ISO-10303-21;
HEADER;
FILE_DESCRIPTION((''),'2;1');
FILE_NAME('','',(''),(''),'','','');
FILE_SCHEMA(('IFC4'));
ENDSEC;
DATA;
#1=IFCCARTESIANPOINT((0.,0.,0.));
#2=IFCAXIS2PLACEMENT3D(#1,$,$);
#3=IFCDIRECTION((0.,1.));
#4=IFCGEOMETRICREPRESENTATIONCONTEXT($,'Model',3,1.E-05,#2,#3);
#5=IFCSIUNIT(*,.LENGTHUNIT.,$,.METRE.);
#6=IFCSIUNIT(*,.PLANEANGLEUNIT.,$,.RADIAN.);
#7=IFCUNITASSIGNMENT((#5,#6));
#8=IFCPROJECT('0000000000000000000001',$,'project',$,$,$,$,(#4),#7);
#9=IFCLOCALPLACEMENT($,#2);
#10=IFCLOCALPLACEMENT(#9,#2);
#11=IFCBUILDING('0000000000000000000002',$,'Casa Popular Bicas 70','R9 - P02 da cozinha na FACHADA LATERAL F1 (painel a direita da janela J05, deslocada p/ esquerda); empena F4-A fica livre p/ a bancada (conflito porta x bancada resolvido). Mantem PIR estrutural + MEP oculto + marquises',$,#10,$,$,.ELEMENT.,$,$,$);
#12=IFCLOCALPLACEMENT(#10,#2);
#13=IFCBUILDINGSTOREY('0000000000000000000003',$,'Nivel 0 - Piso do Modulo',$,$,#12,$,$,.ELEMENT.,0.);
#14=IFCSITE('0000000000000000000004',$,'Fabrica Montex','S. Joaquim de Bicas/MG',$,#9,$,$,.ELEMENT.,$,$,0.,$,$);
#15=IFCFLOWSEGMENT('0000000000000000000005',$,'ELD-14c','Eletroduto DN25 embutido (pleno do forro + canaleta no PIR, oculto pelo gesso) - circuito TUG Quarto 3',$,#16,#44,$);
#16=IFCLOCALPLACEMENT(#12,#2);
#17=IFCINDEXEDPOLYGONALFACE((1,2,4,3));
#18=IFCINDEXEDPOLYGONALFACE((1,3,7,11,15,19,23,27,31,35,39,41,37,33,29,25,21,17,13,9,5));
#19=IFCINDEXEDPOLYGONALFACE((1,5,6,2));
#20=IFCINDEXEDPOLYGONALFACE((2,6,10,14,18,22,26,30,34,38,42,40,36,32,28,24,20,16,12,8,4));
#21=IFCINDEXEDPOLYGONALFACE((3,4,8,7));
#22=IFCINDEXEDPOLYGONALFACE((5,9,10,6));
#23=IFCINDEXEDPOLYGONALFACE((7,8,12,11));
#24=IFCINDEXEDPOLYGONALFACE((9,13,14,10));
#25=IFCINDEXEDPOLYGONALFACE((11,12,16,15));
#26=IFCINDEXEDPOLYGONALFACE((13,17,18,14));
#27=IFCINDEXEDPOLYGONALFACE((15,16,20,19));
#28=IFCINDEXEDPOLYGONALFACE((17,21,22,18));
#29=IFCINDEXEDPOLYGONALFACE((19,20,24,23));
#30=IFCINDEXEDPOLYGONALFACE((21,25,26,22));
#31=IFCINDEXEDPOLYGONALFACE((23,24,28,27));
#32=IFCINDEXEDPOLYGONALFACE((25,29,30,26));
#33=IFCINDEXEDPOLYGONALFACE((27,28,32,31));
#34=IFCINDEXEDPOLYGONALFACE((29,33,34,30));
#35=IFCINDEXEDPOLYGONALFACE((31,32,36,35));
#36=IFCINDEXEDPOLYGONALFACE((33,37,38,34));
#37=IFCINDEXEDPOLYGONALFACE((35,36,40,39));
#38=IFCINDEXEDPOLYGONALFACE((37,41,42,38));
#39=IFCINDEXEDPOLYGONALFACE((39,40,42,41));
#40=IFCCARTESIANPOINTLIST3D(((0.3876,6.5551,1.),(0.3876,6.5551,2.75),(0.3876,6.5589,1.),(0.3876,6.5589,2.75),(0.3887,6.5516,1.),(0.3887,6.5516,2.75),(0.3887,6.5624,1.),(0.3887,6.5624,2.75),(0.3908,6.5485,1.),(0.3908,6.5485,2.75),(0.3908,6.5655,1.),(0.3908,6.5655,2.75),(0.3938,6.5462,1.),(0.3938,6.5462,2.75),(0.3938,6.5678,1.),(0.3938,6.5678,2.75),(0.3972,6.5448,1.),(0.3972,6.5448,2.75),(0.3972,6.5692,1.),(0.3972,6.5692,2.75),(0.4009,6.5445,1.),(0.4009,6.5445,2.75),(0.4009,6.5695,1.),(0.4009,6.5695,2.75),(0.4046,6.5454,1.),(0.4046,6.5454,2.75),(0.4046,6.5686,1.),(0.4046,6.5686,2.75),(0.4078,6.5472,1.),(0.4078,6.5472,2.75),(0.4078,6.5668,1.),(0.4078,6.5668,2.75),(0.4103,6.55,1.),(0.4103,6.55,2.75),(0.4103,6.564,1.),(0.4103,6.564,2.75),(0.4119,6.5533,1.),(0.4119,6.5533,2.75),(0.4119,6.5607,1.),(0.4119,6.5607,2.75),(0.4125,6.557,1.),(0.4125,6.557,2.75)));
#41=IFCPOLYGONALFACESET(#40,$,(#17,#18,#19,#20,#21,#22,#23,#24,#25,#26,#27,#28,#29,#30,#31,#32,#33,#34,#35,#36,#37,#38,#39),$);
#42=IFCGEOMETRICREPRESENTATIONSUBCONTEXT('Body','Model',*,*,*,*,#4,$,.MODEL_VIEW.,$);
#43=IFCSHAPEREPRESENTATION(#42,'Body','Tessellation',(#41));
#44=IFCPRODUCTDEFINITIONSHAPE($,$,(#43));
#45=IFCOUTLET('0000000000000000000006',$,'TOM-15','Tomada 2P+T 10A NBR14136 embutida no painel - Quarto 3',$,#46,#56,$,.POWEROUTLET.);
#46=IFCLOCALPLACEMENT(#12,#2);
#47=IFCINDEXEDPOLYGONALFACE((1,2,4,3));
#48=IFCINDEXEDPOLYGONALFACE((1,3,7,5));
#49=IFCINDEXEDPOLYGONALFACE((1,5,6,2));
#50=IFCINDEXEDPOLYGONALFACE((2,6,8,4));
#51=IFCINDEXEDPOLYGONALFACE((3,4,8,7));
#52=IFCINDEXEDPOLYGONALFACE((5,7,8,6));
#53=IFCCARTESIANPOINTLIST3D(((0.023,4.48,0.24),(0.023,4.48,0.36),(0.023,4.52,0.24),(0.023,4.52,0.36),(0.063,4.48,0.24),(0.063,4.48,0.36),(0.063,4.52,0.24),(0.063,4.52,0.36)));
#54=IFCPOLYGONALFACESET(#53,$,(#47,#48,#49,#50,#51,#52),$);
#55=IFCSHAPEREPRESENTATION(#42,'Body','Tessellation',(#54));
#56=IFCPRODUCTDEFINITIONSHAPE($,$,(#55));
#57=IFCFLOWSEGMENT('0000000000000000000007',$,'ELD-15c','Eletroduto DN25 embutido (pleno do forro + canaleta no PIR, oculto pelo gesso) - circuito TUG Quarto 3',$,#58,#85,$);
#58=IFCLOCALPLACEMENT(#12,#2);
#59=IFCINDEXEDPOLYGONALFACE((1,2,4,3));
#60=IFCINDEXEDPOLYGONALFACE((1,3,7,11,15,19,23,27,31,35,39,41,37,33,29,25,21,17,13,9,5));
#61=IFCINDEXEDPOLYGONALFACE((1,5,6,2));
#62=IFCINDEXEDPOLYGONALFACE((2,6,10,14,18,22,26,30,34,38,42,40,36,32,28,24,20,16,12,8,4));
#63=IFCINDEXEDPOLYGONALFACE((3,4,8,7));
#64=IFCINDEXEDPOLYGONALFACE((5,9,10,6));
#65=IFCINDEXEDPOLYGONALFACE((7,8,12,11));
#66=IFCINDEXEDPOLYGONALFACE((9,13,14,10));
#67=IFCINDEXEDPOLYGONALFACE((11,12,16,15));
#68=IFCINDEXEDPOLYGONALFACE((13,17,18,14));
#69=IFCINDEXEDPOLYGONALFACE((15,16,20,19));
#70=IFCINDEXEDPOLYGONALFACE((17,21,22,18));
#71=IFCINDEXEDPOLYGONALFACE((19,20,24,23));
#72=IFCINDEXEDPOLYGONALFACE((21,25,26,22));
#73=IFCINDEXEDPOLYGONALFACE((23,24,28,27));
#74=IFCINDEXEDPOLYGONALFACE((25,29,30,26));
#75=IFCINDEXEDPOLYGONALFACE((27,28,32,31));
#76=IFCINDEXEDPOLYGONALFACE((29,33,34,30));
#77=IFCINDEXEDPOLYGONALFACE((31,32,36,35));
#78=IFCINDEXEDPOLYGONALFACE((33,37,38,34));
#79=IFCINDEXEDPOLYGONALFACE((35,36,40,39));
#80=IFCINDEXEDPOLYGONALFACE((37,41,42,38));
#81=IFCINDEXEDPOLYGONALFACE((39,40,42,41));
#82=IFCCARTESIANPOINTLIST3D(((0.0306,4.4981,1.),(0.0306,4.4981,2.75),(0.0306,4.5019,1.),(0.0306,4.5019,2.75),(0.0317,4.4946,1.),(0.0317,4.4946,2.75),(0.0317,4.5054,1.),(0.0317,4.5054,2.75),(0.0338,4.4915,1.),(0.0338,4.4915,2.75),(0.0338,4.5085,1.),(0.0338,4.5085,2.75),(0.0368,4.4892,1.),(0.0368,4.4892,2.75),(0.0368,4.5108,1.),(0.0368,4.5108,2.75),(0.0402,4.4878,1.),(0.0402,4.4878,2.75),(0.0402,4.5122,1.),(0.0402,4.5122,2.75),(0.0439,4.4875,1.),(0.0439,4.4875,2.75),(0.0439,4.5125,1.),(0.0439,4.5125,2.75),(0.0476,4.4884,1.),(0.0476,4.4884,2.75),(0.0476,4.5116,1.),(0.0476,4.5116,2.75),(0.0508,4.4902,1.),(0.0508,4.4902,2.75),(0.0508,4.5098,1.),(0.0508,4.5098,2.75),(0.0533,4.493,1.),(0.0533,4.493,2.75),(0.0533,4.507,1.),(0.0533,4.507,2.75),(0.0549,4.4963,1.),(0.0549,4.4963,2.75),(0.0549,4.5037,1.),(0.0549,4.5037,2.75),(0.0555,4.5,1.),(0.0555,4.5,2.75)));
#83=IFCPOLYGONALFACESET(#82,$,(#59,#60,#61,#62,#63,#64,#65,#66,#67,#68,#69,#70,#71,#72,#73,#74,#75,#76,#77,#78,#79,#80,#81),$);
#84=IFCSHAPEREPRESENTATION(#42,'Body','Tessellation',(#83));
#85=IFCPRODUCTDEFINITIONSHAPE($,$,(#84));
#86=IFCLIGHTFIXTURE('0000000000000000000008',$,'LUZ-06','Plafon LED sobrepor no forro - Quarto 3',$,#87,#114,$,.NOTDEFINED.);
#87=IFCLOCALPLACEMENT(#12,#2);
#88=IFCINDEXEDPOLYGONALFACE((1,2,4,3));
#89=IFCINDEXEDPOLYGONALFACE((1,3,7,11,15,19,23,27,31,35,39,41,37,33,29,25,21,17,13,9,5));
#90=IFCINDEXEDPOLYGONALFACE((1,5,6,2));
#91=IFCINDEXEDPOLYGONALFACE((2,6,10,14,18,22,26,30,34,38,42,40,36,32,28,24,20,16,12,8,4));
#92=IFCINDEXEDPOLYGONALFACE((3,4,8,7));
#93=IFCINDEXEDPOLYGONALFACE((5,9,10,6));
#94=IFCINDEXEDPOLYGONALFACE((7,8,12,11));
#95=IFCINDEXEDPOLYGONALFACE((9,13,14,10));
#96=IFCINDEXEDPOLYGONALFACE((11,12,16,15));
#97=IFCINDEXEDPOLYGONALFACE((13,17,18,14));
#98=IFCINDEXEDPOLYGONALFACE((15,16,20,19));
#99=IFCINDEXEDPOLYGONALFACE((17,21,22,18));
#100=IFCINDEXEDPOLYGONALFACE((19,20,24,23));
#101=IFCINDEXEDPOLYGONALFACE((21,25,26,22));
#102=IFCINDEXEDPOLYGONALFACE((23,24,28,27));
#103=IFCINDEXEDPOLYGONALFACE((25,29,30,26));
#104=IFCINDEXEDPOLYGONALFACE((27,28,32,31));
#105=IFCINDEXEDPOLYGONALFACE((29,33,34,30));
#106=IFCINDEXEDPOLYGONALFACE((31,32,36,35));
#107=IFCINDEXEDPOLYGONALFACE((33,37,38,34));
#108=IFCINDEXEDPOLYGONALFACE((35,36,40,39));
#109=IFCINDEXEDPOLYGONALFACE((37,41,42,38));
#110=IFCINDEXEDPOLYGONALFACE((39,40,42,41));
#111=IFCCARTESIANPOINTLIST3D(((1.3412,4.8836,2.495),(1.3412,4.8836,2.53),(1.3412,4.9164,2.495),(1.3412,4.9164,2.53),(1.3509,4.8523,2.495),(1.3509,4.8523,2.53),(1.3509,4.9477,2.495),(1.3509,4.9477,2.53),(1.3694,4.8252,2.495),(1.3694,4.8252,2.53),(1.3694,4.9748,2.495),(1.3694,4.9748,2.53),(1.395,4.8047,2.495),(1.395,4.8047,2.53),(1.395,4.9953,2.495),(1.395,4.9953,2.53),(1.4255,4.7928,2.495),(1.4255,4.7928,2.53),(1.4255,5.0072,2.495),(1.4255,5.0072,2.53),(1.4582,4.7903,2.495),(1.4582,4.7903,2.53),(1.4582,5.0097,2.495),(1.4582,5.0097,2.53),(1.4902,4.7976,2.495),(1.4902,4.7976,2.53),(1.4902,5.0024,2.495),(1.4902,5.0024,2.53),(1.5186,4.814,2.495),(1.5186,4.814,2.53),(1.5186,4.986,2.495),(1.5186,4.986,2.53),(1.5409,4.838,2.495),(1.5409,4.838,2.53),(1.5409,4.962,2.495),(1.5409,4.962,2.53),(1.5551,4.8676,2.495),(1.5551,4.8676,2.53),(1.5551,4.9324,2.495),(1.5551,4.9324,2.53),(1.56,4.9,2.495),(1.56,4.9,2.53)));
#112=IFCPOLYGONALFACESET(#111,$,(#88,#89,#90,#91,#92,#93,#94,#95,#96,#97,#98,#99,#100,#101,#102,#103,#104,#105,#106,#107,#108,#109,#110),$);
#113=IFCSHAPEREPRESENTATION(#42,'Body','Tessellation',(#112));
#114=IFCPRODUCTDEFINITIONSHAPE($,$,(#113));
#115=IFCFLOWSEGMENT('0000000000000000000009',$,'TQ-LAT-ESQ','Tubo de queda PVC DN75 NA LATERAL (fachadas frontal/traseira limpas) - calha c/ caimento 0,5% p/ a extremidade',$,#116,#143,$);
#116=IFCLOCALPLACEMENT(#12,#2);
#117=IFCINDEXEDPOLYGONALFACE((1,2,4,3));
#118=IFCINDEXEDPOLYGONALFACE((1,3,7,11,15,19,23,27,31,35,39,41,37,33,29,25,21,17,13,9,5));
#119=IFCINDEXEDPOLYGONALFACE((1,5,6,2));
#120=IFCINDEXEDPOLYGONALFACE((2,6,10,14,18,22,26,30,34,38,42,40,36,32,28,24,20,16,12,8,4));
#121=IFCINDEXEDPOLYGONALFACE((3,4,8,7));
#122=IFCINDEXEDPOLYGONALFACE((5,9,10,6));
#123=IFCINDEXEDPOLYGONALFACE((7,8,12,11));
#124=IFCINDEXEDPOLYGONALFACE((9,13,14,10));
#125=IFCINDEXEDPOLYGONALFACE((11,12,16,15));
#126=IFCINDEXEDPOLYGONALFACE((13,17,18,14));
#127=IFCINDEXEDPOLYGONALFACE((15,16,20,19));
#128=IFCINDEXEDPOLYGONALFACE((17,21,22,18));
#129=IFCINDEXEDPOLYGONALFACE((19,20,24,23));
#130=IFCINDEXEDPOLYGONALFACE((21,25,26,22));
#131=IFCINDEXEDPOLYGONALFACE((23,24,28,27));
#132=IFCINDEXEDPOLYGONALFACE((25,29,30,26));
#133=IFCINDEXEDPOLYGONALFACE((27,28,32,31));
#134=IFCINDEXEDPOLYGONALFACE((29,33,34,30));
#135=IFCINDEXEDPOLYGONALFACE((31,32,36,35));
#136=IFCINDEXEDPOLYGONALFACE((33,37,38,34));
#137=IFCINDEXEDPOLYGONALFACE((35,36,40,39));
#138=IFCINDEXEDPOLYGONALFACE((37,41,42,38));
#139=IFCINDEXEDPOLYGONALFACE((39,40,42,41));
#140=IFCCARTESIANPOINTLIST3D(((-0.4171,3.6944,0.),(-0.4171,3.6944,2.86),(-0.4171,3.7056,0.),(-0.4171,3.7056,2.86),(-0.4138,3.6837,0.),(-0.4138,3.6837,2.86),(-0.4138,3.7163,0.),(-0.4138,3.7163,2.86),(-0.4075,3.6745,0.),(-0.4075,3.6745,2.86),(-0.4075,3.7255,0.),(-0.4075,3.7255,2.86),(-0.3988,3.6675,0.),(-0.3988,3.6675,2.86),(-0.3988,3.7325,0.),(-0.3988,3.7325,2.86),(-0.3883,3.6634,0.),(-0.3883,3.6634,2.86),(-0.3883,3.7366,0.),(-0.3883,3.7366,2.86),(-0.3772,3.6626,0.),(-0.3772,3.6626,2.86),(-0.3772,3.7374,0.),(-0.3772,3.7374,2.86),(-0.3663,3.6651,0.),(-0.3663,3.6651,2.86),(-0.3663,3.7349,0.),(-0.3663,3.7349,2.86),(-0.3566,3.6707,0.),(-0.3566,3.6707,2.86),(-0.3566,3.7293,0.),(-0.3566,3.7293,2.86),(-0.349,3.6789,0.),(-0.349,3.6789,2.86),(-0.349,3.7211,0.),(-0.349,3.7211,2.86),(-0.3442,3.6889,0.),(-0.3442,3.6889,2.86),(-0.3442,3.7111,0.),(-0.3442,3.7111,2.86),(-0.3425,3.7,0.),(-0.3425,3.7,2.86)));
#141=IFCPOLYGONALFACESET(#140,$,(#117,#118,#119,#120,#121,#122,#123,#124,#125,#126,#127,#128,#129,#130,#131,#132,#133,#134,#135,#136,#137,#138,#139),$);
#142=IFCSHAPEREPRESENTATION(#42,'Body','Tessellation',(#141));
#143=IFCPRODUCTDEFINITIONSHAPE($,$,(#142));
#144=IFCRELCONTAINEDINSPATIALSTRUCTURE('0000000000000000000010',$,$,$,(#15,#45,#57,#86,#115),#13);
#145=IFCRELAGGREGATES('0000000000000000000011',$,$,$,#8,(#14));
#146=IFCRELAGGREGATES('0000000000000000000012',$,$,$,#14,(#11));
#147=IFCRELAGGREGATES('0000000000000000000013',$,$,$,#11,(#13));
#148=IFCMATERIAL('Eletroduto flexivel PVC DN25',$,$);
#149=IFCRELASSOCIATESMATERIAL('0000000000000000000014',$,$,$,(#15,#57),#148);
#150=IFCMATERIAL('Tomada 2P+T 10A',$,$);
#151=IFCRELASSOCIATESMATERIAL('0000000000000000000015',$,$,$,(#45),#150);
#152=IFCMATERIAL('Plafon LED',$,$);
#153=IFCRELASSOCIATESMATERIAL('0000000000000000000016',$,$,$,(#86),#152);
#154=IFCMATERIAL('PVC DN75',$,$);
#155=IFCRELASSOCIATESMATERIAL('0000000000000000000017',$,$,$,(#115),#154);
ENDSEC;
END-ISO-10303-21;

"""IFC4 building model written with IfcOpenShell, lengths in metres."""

from ifc_helpers import new_model, si_unit, direction, frame, frame_2d, origin, origin_2d, place, context, subcontext, project, spatial, rectangle, circle, extrude, material, element, save


model = new_model("IFC4")

# Units and contexts
model_context = context("Model", 3, precision=1e-05, world=origin(), true_north=direction((0.0, 1.0)))
body_context = subcontext(model_context, "Body", "Model", "MODEL_VIEW")
ifc_project = project(units=[si_unit("LENGTHUNIT", "METRE"), si_unit("PLANEANGLEUNIT", "RADIAN")], contexts=[model_context])

# Site, building, storey
site_placement = place(None, origin())
site = spatial("IfcSite", under=ifc_project, at=site_placement, Name="Fabrica Montex", Description="S. Joaquim de Bicas/MG", CompositionType="ELEMENT", RefElevation=0.0)
building_placement = place(site_placement, origin())
building = spatial("IfcBuilding", under=site, at=building_placement, Name="Casa Popular Bicas 70", Description="R9 - P02 da cozinha na FACHADA LATERAL F1 (painel a direita da janela J05, deslocada p/ esquerda); empena F4-A fica livre p/ a bancada (conflito porta x bancada resolvido). Mantem PIR estrutural + MEP oculto + marquises", CompositionType="ELEMENT")
storey_placement = place(building_placement, origin())
storey = spatial("IfcBuildingStorey", under=building, at=storey_placement, Name="Nivel 0 - Piso do Modulo", CompositionType="ELEMENT", Elevation=0.0)

# Shared definitions
ifc_material_1 = material(Name="Tomada 2P+T 10A")

# Flow segment
ifc_material_2 = material(Name="Eletroduto flexivel PVC DN25")
flow_segment_1_placement = place(storey_placement, frame((0.4, 6.557, 2.75), z_axis=(0.0, 0.0, -1.0), x_axis=(1.0, 0.0, 0.0)))
element("IfcFlowSegment", 1, at=flow_segment_1_placement, inside=storey, material=ifc_material_2, Name="ELD-14c", Description="Eletroduto DN25 embutido (pleno do forro + canaleta no PIR, oculto pelo gesso) - circuito TUG Quarto 3", context=body_context, shape_type="SweptSolid", body=[
    extrude(circle(Radius=0.0125, at=origin_2d()), origin(), (0.0, 0.0, 1.0), 1.75),
])

# Outlet
outlet_1_placement = place(storey_placement, frame((0.023, 4.48, 0.24)))
element("IfcOutlet", 2, at=outlet_1_placement, inside=storey, material=ifc_material_1, Name="TOM-15", Description="Tomada 2P+T 10A NBR14136 embutida no painel - Quarto 3", PredefinedType="POWEROUTLET", context=body_context, shape_type="SweptSolid", body=[
    extrude(rectangle(XDim=0.04, YDim=0.04, at=frame_2d((0.02, 0.02))), origin(), (0.0, 0.0, 1.0), 0.12),
])

# Flow segment
flow_segment_2_placement = place(storey_placement, frame((0.043, 4.5, 2.75), z_axis=(0.0, 0.0, -1.0), x_axis=(1.0, 0.0, 0.0)))
element("IfcFlowSegment", 3, at=flow_segment_2_placement, inside=storey, material=ifc_material_2, Name="ELD-15c", Description="Eletroduto DN25 embutido (pleno do forro + canaleta no PIR, oculto pelo gesso) - circuito TUG Quarto 3", context=body_context, shape_type="SweptSolid", body=[
    extrude(circle(Radius=0.0125, at=origin_2d()), origin(), (0.0, 0.0, 1.0), 1.75),
])

# Light fixture
ifc_material_3 = material(Name="Plafon LED")
light_fixture_placement = place(storey_placement, frame((1.45, 4.9, 2.495)))
element("IfcLightFixture", 4, at=light_fixture_placement, inside=storey, material=ifc_material_3, Name="LUZ-06", Description="Plafon LED sobrepor no forro - Quarto 3", PredefinedType="NOTDEFINED", context=body_context, shape_type="SweptSolid", body=[
    extrude(circle(Radius=0.11, at=origin_2d()), origin(), (0.0, 0.0, 1.0), 0.035),
])

# Flow segment
ifc_material_4 = material(Name="PVC DN75")
flow_segment_3_placement = place(storey_placement, frame((-0.38, 3.7, 0.0)))
element("IfcFlowSegment", 5, at=flow_segment_3_placement, inside=storey, material=ifc_material_4, Name="TQ-LAT-ESQ", Description="Tubo de queda PVC DN75 NA LATERAL (fachadas frontal/traseira limpas) - calha c/ caimento 0,5% p/ a extremidade", context=body_context, shape_type="SweptSolid", body=[
    extrude(circle(Radius=0.0375, at=origin_2d()), origin(), (0.0, 0.0, 1.0), 2.86),
])

save(model, "model.ifc")
